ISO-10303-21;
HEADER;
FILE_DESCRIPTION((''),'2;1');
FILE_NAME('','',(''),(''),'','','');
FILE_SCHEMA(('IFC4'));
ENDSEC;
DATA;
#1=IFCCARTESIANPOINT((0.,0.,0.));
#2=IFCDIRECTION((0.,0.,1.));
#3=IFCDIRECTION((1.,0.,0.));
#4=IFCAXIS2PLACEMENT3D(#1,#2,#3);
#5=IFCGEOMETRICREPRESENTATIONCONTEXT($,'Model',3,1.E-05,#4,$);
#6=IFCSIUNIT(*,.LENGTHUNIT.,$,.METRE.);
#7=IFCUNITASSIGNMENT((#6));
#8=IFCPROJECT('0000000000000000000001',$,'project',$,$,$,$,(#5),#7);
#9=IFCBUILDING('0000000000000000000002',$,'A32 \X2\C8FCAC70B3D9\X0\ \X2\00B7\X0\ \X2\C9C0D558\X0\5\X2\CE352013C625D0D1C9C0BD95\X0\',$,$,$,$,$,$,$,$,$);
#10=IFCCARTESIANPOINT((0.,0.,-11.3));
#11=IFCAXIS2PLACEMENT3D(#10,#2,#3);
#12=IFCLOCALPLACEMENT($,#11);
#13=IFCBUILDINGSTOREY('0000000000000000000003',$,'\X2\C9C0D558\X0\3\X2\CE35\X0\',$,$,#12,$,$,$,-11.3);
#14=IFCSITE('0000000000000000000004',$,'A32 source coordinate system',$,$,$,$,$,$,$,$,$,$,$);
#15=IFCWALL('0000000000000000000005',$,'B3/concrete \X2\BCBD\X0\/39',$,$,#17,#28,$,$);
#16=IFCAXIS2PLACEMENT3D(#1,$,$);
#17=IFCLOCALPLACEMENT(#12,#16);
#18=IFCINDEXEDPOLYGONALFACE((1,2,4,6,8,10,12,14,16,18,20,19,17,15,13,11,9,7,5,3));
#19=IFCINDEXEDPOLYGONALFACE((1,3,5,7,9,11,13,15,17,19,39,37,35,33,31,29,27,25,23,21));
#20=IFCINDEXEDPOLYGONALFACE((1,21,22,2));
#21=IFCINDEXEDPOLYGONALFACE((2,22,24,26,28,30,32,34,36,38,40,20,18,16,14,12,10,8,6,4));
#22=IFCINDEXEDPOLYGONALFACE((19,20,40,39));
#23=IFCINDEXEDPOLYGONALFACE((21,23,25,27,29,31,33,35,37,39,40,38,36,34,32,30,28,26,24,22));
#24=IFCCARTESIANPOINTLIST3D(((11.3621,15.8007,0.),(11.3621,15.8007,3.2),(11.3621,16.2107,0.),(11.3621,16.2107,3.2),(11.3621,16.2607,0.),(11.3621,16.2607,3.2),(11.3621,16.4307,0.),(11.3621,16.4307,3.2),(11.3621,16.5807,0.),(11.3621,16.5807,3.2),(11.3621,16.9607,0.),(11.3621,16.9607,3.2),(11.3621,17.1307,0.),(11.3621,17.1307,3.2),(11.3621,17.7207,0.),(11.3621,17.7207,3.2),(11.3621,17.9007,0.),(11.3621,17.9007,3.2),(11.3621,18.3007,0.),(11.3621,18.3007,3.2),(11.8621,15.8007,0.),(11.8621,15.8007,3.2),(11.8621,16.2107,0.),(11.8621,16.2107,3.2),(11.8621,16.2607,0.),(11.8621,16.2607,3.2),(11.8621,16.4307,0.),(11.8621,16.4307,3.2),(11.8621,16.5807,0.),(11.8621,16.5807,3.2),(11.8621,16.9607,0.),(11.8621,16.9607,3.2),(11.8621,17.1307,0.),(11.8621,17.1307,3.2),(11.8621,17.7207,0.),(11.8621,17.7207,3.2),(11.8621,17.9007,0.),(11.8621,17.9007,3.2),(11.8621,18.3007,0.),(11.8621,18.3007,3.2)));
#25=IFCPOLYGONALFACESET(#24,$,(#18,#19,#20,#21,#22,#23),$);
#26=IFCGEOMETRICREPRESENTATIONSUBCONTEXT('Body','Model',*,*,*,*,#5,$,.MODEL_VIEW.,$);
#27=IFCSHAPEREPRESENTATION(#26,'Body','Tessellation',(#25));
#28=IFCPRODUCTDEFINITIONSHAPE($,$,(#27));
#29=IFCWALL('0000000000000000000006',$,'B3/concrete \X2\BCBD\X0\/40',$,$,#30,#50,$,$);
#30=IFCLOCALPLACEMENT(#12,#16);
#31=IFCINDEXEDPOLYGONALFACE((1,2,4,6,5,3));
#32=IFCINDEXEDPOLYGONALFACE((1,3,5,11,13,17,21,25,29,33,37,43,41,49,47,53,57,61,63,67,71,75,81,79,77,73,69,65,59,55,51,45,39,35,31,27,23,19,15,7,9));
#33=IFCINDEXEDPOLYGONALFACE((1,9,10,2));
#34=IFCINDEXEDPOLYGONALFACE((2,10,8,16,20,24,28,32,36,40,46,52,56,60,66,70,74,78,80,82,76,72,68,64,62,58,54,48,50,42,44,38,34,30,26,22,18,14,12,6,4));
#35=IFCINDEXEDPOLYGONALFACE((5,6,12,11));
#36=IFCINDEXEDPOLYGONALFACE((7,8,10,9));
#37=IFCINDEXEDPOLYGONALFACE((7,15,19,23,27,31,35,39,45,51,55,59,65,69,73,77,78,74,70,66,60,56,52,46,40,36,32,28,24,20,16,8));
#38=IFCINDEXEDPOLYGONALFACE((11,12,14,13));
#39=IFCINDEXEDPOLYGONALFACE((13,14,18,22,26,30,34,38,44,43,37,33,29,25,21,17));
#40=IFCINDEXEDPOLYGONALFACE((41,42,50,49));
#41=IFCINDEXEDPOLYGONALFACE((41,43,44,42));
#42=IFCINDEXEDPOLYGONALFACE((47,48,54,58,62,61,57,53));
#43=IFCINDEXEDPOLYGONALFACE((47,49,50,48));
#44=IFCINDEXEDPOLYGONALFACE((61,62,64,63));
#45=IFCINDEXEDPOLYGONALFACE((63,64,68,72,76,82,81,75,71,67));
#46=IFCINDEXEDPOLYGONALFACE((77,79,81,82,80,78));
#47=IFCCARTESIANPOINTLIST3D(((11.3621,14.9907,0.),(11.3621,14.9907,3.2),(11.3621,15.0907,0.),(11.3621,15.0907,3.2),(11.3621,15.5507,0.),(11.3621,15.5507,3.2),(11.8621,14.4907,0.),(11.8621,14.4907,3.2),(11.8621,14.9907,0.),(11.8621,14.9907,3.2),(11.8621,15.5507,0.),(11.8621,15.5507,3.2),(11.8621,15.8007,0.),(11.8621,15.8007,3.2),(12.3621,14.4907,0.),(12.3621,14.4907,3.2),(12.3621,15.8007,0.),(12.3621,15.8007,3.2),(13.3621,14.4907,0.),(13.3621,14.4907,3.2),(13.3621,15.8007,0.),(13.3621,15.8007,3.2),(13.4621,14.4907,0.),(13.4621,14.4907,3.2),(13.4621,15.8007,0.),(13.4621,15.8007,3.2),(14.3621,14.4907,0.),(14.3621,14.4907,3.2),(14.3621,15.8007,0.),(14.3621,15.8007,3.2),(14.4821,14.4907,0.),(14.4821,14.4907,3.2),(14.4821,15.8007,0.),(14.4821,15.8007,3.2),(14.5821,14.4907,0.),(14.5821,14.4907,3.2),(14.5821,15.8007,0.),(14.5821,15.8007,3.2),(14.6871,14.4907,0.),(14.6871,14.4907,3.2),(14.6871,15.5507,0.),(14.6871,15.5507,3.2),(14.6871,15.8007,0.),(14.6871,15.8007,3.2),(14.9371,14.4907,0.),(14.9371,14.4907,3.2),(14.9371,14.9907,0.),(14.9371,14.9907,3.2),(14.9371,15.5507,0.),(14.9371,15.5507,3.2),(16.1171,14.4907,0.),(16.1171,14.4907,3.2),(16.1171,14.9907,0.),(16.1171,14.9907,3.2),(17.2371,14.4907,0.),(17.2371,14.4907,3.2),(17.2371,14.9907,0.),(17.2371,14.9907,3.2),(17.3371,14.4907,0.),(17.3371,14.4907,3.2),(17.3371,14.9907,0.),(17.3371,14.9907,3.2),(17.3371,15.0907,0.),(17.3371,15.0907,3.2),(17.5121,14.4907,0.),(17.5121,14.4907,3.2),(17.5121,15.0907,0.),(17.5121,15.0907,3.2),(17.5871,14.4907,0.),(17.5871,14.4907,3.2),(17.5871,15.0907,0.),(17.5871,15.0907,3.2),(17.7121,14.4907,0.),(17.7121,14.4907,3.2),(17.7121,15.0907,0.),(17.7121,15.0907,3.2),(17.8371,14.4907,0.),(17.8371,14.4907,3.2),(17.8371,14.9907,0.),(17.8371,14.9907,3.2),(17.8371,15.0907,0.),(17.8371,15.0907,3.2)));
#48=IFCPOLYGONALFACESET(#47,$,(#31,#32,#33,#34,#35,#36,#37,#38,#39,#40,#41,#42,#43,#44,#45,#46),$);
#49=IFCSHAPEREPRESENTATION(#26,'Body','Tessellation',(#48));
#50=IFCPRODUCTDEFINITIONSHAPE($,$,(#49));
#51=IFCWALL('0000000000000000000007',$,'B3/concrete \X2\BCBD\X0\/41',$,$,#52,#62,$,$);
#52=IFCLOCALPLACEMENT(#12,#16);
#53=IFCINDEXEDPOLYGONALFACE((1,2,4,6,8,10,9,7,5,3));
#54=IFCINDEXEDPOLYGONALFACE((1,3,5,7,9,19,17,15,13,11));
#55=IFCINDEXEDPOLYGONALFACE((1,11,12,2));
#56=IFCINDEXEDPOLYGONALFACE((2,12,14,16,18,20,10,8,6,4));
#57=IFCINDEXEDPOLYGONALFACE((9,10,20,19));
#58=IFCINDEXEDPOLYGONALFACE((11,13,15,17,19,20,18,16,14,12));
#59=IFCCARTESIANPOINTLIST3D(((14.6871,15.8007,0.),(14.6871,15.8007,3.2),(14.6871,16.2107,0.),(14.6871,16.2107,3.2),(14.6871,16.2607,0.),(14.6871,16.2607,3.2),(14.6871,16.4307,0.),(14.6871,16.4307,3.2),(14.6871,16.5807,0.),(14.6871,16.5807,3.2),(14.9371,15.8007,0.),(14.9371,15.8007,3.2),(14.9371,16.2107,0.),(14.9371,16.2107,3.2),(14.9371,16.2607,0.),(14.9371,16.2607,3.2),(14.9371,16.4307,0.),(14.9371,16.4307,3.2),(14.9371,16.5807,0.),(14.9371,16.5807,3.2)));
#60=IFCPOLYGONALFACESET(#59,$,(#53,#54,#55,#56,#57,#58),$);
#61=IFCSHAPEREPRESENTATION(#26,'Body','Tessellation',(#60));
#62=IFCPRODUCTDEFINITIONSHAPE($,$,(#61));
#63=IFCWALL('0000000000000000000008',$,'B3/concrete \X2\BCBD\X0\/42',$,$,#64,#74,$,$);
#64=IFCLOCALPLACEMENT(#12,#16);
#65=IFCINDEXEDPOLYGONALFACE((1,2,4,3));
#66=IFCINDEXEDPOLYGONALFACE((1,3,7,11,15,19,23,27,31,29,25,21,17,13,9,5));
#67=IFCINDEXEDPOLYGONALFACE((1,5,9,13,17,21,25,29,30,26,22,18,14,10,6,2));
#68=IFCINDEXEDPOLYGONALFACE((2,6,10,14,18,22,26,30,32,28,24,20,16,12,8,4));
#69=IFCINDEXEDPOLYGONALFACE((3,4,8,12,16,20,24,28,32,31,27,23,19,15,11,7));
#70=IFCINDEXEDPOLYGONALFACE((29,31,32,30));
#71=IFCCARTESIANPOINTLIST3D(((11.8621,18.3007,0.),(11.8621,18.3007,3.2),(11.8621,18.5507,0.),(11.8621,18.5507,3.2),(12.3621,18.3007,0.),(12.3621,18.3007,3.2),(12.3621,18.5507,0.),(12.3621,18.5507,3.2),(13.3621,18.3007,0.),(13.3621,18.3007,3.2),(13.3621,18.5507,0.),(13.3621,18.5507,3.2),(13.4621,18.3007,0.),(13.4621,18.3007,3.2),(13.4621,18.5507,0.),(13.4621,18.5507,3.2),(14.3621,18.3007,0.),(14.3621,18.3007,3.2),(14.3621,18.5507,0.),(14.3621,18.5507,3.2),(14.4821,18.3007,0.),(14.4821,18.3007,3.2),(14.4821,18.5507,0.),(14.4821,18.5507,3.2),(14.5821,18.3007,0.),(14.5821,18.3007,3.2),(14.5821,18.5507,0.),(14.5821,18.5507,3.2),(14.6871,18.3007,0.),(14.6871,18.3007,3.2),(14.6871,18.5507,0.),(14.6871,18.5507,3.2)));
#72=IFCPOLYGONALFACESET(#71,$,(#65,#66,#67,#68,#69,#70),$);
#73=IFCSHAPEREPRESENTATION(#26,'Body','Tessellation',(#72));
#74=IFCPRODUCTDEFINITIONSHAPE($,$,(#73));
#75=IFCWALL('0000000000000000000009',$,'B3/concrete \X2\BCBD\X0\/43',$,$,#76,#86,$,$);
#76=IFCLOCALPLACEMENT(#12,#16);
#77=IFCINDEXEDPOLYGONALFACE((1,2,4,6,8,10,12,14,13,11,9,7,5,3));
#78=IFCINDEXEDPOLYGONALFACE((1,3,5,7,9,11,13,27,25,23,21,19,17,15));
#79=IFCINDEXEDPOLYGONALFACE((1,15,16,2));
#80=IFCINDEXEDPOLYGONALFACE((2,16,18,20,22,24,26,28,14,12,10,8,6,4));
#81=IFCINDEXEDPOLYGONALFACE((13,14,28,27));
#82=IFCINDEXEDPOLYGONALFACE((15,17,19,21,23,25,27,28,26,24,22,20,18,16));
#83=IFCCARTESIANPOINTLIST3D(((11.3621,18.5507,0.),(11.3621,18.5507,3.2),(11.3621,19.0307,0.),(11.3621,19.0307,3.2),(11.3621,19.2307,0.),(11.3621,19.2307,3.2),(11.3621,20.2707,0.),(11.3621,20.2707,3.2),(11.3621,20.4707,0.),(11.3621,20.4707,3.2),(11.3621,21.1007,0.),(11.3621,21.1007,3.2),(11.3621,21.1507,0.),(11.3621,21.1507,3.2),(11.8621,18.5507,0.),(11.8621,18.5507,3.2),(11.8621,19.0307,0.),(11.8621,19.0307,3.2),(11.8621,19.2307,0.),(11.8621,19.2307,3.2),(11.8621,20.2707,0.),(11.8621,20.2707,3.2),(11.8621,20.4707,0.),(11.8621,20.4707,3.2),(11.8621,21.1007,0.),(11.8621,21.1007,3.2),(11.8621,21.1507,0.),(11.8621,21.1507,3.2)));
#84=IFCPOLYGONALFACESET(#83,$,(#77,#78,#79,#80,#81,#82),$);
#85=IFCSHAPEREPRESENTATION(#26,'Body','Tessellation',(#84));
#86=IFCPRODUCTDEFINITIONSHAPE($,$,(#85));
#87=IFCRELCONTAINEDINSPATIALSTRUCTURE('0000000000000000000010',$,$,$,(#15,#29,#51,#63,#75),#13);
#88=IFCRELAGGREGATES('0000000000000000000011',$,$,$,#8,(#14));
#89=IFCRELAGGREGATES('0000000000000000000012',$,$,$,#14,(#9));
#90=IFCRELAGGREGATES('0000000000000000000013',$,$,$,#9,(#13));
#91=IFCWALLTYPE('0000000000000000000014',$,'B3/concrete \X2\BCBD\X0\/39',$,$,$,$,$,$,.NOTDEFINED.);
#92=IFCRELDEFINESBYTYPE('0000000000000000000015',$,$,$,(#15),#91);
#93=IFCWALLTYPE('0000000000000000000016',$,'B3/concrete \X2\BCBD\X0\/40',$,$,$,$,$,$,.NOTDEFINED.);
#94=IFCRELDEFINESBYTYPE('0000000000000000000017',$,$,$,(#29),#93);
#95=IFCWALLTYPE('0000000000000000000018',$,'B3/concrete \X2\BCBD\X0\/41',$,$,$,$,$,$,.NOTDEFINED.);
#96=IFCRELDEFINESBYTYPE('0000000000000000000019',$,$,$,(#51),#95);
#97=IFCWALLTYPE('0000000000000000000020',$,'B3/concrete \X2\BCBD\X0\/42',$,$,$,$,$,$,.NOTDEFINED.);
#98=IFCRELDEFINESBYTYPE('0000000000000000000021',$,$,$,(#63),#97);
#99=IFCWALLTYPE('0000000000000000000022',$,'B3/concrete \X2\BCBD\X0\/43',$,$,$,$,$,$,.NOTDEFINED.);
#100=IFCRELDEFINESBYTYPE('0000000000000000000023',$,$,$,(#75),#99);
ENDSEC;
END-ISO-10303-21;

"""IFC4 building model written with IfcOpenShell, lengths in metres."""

from ifc_helpers import new_model, si_unit, frame, origin, origin_with_axes, place, context, subcontext, project, spatial, polyline, outline, extrude, source, transform, mapped, type_object, type_shapes, element, save


model = new_model("IFC4")

# Units and contexts
model_context = context("Model", 3, precision=1e-05, world=origin_with_axes())
body_context = subcontext(model_context, "Body", "Model", "MODEL_VIEW")
ifc_project = project(units=[si_unit("LENGTHUNIT", "METRE")], contexts=[model_context])

# Site, building, storey
site = spatial("IfcSite", under=ifc_project, Name="A32 source coordinate system")
building = spatial("IfcBuilding", under=site, Name="A32 주거동 · 지하5층–옥탑지붕")
storey_placement = place(None, frame((0.0, 0.0, -11.3), z_axis=(0.0, 0.0, 1.0), x_axis=(1.0, 0.0, 0.0)))
storey = spatial("IfcBuildingStorey", under=building, at=storey_placement, Name="지하3층", Elevation=-11.3)

# Walls
wall_type_1 = type_object("IfcWallType", Name="B3/concrete 벽/39", PredefinedType="NOTDEFINED")
shared_shape_1 = source(origin(), body_context, "Body", "SweptSolid", [
    extrude(outline(polyline([(11.3621, 16.9607), (11.3621, 17.1307), (11.3621, 17.7207), (11.3621, 17.9007), (11.3621, 18.3007), (11.8621, 18.3007), (11.8621, 17.9007), (11.8621, 17.7207), (11.8621, 17.1307), (11.8621, 16.9607), (11.8621, 16.5807), (11.8621, 16.4307), (11.8621, 16.2607), (11.8621, 16.2107), (11.8621, 15.8007), (11.3621, 15.8007), (11.3621, 16.2107), (11.3621, 16.2607), (11.3621, 16.4307), (11.3621, 16.5807), (11.3621, 16.9607)])), origin(), (0.0, 0.0, 1.0), 3.2),
])
type_shapes(wall_type_1, [shared_shape_1])
wall_1_placement = place(storey_placement, origin_with_axes())
element("IfcWall", 1, at=wall_1_placement, inside=storey, type_object=wall_type_1, Name="B3/concrete 벽/39", context=body_context, shape_type="MappedRepresentation", body=[
    mapped(shared_shape_1, transform((0.0, 0.0, 0.0), scale=1.0)),
])
wall_type_2 = type_object("IfcWallType", Name="B3/concrete 벽/40", PredefinedType="NOTDEFINED")
shared_shape_2 = source(origin(), body_context, "Body", "SweptSolid", [
    extrude(outline(polyline([(13.4621, 15.8007), (14.3621, 15.8007), (14.4821, 15.8007), (14.5821, 15.8007), (14.6871, 15.8007), (14.6871, 15.5507), (14.9371, 15.5507), (14.9371, 14.9907), (16.1171, 14.9907), (17.2371, 14.9907), (17.3371, 14.9907), (17.3371, 15.0907), (17.5121, 15.0907), (17.5871, 15.0907), (17.7121, 15.0907), (17.8371, 15.0907), (17.8371, 14.9907), (17.8371, 14.4907), (17.7121, 14.4907), (17.5871, 14.4907), (17.5121, 14.4907), (17.3371, 14.4907), (17.2371, 14.4907), (16.1171, 14.4907), (14.9371, 14.4907), (14.6871, 14.4907), (14.5821, 14.4907), (14.4821, 14.4907), (14.3621, 14.4907), (13.4621, 14.4907), (13.3621, 14.4907), (12.3621, 14.4907), (11.8621, 14.4907), (11.8621, 14.9907), (11.3621, 14.9907), (11.3621, 15.0907), (11.3621, 15.5507), (11.8621, 15.5507), (11.8621, 15.8007), (12.3621, 15.8007), (13.3621, 15.8007), (13.4621, 15.8007)])), origin(), (0.0, 0.0, 1.0), 3.2),
])
type_shapes(wall_type_2, [shared_shape_2])
wall_2_placement = place(storey_placement, origin_with_axes())
element("IfcWall", 2, at=wall_2_placement, inside=storey, type_object=wall_type_2, Name="B3/concrete 벽/40", context=body_context, shape_type="MappedRepresentation", body=[
    mapped(shared_shape_2, transform((0.0, 0.0, 0.0), scale=1.0)),
])
wall_type_3 = type_object("IfcWallType", Name="B3/concrete 벽/41", PredefinedType="NOTDEFINED")
shared_shape_3 = source(origin(), body_context, "Body", "SweptSolid", [
    extrude(outline(polyline([(14.6871, 16.4307), (14.6871, 16.5807), (14.9371, 16.5807), (14.9371, 16.4307), (14.9371, 16.2607), (14.9371, 16.2107), (14.9371, 15.8007), (14.6871, 15.8007), (14.6871, 16.2107), (14.6871, 16.2607), (14.6871, 16.4307)])), origin(), (0.0, 0.0, 1.0), 3.2),
])
type_shapes(wall_type_3, [shared_shape_3])
wall_3_placement = place(storey_placement, origin_with_axes())
element("IfcWall", 3, at=wall_3_placement, inside=storey, type_object=wall_type_3, Name="B3/concrete 벽/41", context=body_context, shape_type="MappedRepresentation", body=[
    mapped(shared_shape_3, transform((0.0, 0.0, 0.0), scale=1.0)),
])
wall_type_4 = type_object("IfcWallType", Name="B3/concrete 벽/42", PredefinedType="NOTDEFINED")
shared_shape_4 = source(origin(), body_context, "Body", "SweptSolid", [
    extrude(outline(polyline([(13.3621, 18.5507), (13.4621, 18.5507), (14.3621, 18.5507), (14.4821, 18.5507), (14.5821, 18.5507), (14.6871, 18.5507), (14.6871, 18.3007), (14.5821, 18.3007), (14.4821, 18.3007), (14.3621, 18.3007), (13.4621, 18.3007), (13.3621, 18.3007), (12.3621, 18.3007), (11.8621, 18.3007), (11.8621, 18.5507), (12.3621, 18.5507), (13.3621, 18.5507)])), origin(), (0.0, 0.0, 1.0), 3.2),
])
type_shapes(wall_type_4, [shared_shape_4])
wall_4_placement = place(storey_placement, origin_with_axes())
element("IfcWall", 4, at=wall_4_placement, inside=storey, type_object=wall_type_4, Name="B3/concrete 벽/42", context=body_context, shape_type="MappedRepresentation", body=[
    mapped(shared_shape_4, transform((0.0, 0.0, 0.0), scale=1.0)),
])
wall_type_5 = type_object("IfcWallType", Name="B3/concrete 벽/43", PredefinedType="NOTDEFINED")
shared_shape_5 = source(origin(), body_context, "Body", "SweptSolid", [
    extrude(outline(polyline([(11.3621, 19.2307), (11.3621, 20.2707), (11.3621, 20.4707), (11.3621, 21.1007), (11.3621, 21.1507), (11.8621, 21.1507), (11.8621, 21.1007), (11.8621, 20.4707), (11.8621, 20.2707), (11.8621, 19.2307), (11.8621, 19.0307), (11.8621, 18.5507), (11.3621, 18.5507), (11.3621, 19.0307), (11.3621, 19.2307)])), origin(), (0.0, 0.0, 1.0), 3.2),
])
type_shapes(wall_type_5, [shared_shape_5])
wall_5_placement = place(storey_placement, origin_with_axes())
element("IfcWall", 5, at=wall_5_placement, inside=storey, type_object=wall_type_5, Name="B3/concrete 벽/43", context=body_context, shape_type="MappedRepresentation", body=[
    mapped(shared_shape_5, transform((0.0, 0.0, 0.0), scale=1.0)),
])

save(model, "model.ifc")
